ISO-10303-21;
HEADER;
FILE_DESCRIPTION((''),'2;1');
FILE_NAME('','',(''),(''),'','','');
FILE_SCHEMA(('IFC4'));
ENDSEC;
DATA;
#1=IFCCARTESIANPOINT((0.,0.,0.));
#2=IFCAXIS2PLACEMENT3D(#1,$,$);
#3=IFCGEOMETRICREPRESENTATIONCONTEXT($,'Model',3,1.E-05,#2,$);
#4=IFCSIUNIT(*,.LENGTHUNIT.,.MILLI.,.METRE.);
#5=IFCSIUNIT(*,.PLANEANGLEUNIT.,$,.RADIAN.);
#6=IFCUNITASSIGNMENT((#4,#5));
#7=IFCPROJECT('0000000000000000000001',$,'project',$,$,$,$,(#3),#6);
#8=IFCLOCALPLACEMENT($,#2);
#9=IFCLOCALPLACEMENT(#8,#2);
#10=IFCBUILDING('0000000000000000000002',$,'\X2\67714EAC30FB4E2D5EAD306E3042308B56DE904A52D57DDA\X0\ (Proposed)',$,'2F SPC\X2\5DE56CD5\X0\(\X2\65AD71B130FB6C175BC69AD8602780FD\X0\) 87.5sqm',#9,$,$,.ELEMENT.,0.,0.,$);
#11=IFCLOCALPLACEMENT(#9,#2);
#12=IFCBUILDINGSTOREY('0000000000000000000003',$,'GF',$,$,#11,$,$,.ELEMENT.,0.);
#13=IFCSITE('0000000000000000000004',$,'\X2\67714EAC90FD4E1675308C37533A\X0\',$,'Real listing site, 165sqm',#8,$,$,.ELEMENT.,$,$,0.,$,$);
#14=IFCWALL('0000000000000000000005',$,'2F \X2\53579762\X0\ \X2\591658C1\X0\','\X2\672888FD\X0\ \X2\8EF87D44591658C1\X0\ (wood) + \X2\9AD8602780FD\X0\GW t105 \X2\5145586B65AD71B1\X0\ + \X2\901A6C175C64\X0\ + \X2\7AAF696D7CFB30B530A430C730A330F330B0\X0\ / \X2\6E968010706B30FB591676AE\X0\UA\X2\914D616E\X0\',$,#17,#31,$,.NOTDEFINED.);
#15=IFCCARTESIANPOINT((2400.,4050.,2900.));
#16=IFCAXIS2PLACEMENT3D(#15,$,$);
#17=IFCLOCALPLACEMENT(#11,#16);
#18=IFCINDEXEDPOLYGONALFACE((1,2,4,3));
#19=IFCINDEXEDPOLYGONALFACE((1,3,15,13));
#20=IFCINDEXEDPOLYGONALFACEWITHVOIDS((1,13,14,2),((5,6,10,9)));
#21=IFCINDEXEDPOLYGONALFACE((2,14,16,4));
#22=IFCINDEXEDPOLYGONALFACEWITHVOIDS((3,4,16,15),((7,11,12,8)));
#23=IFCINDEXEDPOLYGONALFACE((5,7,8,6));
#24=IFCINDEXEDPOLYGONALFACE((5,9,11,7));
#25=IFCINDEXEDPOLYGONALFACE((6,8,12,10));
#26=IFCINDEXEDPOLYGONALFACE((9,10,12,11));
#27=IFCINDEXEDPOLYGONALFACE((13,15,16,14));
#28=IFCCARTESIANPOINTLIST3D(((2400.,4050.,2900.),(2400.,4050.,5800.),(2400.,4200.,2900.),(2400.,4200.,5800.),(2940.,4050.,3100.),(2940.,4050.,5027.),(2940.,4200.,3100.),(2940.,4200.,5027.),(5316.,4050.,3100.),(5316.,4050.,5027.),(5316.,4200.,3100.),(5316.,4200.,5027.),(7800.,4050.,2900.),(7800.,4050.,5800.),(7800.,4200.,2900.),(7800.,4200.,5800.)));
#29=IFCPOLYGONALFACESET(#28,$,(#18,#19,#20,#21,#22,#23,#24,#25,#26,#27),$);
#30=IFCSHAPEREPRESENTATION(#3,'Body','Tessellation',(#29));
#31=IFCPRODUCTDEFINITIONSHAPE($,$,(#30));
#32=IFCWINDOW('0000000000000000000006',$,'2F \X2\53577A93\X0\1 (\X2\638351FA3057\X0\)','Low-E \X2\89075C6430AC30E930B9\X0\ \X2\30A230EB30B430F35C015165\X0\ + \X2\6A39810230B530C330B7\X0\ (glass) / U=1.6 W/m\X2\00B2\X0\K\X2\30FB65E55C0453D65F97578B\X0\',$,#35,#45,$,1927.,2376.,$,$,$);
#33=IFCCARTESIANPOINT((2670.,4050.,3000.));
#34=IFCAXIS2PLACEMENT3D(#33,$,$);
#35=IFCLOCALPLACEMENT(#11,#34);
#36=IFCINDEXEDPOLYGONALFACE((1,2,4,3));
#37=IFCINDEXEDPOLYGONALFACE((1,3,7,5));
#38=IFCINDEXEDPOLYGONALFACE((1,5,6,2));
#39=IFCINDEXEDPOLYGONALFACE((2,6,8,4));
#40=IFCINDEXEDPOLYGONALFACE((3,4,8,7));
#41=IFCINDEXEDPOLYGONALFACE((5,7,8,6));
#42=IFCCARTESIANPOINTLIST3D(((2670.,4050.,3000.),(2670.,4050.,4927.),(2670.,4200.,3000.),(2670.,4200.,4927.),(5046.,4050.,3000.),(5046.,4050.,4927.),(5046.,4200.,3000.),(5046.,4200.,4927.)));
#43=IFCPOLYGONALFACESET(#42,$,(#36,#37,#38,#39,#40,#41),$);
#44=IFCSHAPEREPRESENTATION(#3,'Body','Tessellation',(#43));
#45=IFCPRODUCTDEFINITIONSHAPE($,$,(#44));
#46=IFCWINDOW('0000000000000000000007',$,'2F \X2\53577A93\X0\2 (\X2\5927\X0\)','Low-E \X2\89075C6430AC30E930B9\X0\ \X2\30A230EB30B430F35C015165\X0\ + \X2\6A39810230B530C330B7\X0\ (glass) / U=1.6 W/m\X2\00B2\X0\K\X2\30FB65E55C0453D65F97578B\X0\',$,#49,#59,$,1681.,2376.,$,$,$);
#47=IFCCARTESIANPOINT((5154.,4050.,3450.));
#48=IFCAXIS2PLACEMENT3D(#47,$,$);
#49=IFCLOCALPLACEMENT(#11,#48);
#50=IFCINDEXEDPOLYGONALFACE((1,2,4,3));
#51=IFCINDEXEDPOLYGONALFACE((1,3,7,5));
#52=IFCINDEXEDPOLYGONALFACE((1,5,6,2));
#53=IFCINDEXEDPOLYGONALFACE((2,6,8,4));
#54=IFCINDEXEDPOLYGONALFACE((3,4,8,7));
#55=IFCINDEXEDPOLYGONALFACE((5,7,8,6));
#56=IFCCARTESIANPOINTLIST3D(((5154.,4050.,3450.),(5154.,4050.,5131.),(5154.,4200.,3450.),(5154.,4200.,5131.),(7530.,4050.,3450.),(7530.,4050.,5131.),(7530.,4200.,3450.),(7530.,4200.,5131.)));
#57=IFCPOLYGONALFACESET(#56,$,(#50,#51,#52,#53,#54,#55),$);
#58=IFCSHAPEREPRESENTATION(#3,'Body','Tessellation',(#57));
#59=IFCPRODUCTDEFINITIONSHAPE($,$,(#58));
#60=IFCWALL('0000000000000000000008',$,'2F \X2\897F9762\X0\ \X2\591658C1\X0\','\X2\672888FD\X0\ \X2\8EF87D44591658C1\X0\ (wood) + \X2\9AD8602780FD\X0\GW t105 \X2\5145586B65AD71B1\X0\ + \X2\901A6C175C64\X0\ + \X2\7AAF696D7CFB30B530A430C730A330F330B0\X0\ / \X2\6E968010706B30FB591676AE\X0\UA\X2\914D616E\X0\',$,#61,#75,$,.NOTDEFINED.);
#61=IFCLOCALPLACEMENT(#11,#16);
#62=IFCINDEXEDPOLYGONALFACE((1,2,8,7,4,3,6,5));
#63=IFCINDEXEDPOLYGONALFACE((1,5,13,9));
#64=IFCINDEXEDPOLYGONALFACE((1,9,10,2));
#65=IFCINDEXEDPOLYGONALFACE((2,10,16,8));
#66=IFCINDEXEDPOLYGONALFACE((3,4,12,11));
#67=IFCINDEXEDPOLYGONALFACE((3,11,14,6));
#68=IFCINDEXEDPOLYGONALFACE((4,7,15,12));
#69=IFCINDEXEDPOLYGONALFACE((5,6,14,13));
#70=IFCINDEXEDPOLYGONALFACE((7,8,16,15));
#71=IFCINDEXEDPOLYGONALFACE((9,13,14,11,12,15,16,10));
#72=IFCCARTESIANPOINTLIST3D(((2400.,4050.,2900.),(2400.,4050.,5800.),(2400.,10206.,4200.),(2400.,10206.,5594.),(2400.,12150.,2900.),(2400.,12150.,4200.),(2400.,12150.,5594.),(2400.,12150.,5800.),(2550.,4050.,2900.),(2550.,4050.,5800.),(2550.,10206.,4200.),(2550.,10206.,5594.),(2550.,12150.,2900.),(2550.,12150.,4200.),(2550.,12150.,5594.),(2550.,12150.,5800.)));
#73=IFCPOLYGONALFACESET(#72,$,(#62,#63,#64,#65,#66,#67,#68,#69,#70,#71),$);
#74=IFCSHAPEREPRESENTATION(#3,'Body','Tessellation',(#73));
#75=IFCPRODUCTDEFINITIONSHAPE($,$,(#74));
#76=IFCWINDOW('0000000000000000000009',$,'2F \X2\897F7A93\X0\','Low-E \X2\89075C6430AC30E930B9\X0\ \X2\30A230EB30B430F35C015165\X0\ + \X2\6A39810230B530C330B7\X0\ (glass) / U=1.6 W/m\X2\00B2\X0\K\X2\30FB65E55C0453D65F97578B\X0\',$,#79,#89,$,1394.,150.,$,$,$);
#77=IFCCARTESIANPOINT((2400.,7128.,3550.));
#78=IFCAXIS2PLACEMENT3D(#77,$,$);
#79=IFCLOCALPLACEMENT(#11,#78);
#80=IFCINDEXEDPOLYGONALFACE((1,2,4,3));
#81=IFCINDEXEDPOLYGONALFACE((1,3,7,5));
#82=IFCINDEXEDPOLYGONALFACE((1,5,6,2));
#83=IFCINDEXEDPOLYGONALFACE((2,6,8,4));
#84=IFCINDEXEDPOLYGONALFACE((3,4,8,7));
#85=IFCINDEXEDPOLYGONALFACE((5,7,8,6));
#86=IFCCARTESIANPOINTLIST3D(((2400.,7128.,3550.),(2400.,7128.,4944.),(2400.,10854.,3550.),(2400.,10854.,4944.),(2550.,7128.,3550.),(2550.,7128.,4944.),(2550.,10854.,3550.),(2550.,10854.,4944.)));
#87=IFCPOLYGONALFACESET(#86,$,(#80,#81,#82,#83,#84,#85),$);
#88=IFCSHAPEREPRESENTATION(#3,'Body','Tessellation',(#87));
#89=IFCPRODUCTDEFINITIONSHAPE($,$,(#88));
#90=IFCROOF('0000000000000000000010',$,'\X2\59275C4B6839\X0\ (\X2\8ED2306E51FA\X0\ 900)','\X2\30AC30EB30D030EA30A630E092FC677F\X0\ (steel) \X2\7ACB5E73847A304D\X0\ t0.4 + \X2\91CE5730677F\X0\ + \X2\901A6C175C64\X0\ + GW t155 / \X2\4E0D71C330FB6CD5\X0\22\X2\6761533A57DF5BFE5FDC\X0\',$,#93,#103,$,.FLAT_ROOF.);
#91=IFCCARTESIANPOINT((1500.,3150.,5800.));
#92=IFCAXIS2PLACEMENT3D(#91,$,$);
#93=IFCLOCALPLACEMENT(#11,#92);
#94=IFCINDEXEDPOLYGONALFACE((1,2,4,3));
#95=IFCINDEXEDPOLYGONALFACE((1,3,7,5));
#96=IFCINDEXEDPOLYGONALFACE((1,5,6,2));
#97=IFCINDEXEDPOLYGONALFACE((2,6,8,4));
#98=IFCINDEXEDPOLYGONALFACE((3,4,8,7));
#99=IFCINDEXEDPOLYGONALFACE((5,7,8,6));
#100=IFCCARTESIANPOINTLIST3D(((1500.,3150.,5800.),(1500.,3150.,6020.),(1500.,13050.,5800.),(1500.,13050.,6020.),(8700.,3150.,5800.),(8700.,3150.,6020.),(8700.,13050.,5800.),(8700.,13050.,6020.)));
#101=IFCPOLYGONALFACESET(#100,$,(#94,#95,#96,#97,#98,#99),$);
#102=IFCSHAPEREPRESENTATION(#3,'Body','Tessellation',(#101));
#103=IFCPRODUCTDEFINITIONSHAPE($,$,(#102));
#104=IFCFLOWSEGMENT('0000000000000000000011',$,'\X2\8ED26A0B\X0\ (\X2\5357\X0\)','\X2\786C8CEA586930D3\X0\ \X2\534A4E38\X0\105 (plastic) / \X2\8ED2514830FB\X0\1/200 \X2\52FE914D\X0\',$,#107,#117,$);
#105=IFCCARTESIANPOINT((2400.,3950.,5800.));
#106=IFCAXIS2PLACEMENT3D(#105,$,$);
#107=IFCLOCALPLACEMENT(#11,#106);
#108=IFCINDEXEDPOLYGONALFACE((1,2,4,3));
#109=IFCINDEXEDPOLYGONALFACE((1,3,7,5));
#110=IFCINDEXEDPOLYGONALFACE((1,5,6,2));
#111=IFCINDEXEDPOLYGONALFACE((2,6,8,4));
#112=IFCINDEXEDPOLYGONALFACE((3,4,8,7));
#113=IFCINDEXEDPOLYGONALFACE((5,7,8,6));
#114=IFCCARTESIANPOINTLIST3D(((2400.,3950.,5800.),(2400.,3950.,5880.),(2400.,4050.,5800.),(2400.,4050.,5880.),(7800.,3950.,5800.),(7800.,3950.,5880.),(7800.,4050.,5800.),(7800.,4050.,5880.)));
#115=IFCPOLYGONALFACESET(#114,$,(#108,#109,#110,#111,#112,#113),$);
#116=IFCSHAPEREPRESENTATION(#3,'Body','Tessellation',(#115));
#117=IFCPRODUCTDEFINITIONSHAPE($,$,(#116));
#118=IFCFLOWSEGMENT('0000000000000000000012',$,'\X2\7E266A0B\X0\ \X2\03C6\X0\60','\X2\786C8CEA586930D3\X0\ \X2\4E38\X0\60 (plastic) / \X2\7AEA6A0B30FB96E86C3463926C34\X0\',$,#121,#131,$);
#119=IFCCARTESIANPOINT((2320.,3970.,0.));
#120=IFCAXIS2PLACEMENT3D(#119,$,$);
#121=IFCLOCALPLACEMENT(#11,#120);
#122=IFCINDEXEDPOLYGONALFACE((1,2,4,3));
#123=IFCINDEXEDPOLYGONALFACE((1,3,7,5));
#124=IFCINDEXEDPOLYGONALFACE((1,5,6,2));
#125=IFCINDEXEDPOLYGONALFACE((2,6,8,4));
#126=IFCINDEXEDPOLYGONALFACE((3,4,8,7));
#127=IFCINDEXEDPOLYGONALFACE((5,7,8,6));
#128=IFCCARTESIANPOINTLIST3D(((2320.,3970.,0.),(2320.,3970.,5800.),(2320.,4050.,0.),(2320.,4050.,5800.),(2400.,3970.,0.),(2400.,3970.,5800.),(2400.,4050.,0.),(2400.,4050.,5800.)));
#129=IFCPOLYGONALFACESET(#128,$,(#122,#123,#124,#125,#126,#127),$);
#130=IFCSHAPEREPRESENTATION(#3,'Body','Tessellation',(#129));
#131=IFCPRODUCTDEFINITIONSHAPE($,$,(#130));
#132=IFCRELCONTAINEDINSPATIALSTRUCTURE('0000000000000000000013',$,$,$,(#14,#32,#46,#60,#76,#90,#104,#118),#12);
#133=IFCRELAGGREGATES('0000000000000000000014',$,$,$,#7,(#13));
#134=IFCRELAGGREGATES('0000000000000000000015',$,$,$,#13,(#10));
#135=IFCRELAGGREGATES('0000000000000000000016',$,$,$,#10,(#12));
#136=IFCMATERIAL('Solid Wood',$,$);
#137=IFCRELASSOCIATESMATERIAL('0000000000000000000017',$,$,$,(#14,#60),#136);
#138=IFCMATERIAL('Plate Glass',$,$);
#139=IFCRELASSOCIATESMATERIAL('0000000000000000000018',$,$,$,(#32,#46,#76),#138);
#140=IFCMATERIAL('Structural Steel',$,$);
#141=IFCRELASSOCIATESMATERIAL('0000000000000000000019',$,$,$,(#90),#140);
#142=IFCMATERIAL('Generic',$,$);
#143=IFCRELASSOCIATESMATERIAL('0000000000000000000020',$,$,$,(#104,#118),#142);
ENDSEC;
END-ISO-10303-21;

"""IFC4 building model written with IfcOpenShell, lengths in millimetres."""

from ifc_helpers import new_model, si_unit, frame, frame_2d, origin, place, context, project, spatial, rectangle, extrude, material, element, fill, save


model = new_model("IFC4")

# Units and contexts
model_context = context("Model", 3, precision=1e-05, world=origin())
ifc_project = project(units=[si_unit("LENGTHUNIT", "METRE", prefix="MILLI"), si_unit("PLANEANGLEUNIT", "RADIAN")], contexts=[model_context])

# Site, building, storey
site_placement = place(None, origin())
site = spatial("IfcSite", under=ifc_project, at=site_placement, Name="東京都世田谷区", ObjectType="Real listing site, 165sqm", CompositionType="ELEMENT", RefElevation=0.0)
building_placement = place(site_placement, origin())
building = spatial("IfcBuilding", under=site, at=building_placement, Name="東京・中庭のある回遊動線 (Proposed)", ObjectType="2F SPC工法(断熱・気密高性能) 87.5sqm", CompositionType="ELEMENT", ElevationOfRefHeight=0.0, ElevationOfTerrain=0.0)
storey_placement = place(building_placement, origin())
storey = spatial("IfcBuildingStorey", under=building, at=storey_placement, Name="GF", CompositionType="ELEMENT", Elevation=0.0)

# Shared definitions
ifc_material_1 = material(Name="Solid Wood")

# Shared definitions
ifc_material_2 = material(Name="Plate Glass")

# Wall, openings, windows
wall_1_placement = place(storey_placement, frame((2400.0, 4050.0, 2900.0)))
wall_1 = element("IfcWall", 1, at=wall_1_placement, inside=storey, material=ifc_material_1, Name="2F 南面 外壁", Description="木製 軸組外壁 (wood) + 高性能GW t105 充填断熱 + 通気層 + 窯業系サイディング / 準耐火・外皮UA配慮", PredefinedType="NOTDEFINED", context=model_context, shape_type="SweptSolid", body=[
    extrude(rectangle(XDim=5400.0, YDim=150.0, at=frame_2d((2700.0, 75.0))), frame((2400.0, 4050.0, 2900.0)), (0.0, 0.0, 1.0), 2900.0),
])
opening_1_placement = place(storey_placement, frame((2670.0, 4050.0, 3000.0)))
opening_1 = element("IfcOpeningElement", 2, at=opening_1_placement, cuts=wall_1, PredefinedType="NOTDEFINED", context=model_context, shape_type="SweptSolid", body=[
    extrude(rectangle(XDim=2376.0, YDim=150.0, at=frame_2d((1188.0, 75.0))), frame((2670.0, 4050.0, 3000.0)), (0.0, 0.0, 1.0), 1927.0),
])
opening_2_placement = place(storey_placement, frame((5154.0, 4050.0, 3450.0)))
opening_2 = element("IfcOpeningElement", 3, at=opening_2_placement, cuts=wall_1, PredefinedType="NOTDEFINED", context=model_context, shape_type="SweptSolid", body=[
    extrude(rectangle(XDim=2376.0, YDim=150.0, at=frame_2d((1188.0, 75.0))), frame((5154.0, 4050.0, 3450.0)), (0.0, 0.0, 1.0), 1681.0),
])
window_1_placement = place(storey_placement, frame((2670.0, 4050.0, 3000.0)))
window_1 = element("IfcWindow", 4, at=window_1_placement, inside=storey, material=ifc_material_2, Name="2F 南窓1 (掃出し)", Description="Low-E 複層ガラス アルゴン封入 + 樹脂サッシ (glass) / U=1.6 W/m²K・日射取得型", OverallHeight=1927.0, OverallWidth=2376.0, context=model_context, shape_type="SweptSolid", body=[
    extrude(rectangle(XDim=2376.0, YDim=150.0, at=frame_2d((1188.0, 75.0))), frame((2670.0, 4050.0, 3000.0)), (0.0, 0.0, 1.0), 1927.0),
])
fill(opening_1, window_1)
window_2_placement = place(storey_placement, frame((5154.0, 4050.0, 3450.0)))
window_2 = element("IfcWindow", 5, at=window_2_placement, inside=storey, material=ifc_material_2, Name="2F 南窓2 (大)", Description="Low-E 複層ガラス アルゴン封入 + 樹脂サッシ (glass) / U=1.6 W/m²K・日射取得型", OverallHeight=1681.0, OverallWidth=2376.0, context=model_context, shape_type="SweptSolid", body=[
    extrude(rectangle(XDim=2376.0, YDim=150.0, at=frame_2d((1188.0, 75.0))), frame((5154.0, 4050.0, 3450.0)), (0.0, 0.0, 1.0), 1681.0),
])
fill(opening_2, window_2)

# Wall, opening, window
wall_2_placement = place(storey_placement, frame((2400.0, 4050.0, 2900.0)))
wall_2 = element("IfcWall", 6, at=wall_2_placement, inside=storey, material=ifc_material_1, Name="2F 西面 外壁", Description="木製 軸組外壁 (wood) + 高性能GW t105 充填断熱 + 通気層 + 窯業系サイディング / 準耐火・外皮UA配慮", PredefinedType="NOTDEFINED", context=model_context, shape_type="SweptSolid", body=[
    extrude(rectangle(XDim=150.0, YDim=8100.0, at=frame_2d((75.0, 4050.0))), frame((2400.0, 4050.0, 2900.0)), (0.0, 0.0, 1.0), 2900.0),
])
opening_3_placement = place(storey_placement, frame((2400.0, 7128.0, 3550.0)))
opening_3 = element("IfcOpeningElement", 7, at=opening_3_placement, cuts=wall_2, PredefinedType="NOTDEFINED", context=model_context, shape_type="SweptSolid", body=[
    extrude(rectangle(XDim=150.0, YDim=3726.0, at=frame_2d((75.0, 1863.0))), frame((2400.0, 7128.0, 3550.0)), (0.0, 0.0, 1.0), 1394.0),
])
window_3_placement = place(storey_placement, frame((2400.0, 7128.0, 3550.0)))
window_3 = element("IfcWindow", 8, at=window_3_placement, inside=storey, material=ifc_material_2, Name="2F 西窓", Description="Low-E 複層ガラス アルゴン封入 + 樹脂サッシ (glass) / U=1.6 W/m²K・日射取得型", OverallHeight=1394.0, OverallWidth=150.0, context=model_context, shape_type="SweptSolid", body=[
    extrude(rectangle(XDim=150.0, YDim=3726.0, at=frame_2d((75.0, 1863.0))), frame((2400.0, 7128.0, 3550.0)), (0.0, 0.0, 1.0), 1394.0),
])
fill(opening_3, window_3)

# Roof
ifc_material_3 = material(Name="Structural Steel")
roof_placement = place(storey_placement, frame((1500.0, 3150.0, 5800.0)))
element("IfcRoof", 9, at=roof_placement, inside=storey, material=ifc_material_3, Name="大屋根 (軒の出 900)", Description="ガルバリウム鋼板 (steel) 立平葺き t0.4 + 野地板 + 通気層 + GW t155 / 不燃・法22条区域対応", PredefinedType="FLAT_ROOF", context=model_context, shape_type="SweptSolid", body=[
    extrude(rectangle(XDim=7200.0, YDim=9900.0, at=frame_2d((3600.0, 4950.0))), frame((1500.0, 3150.0, 5800.0)), (0.0, 0.0, 1.0), 220.0),
])

# Flow segments
ifc_material_4 = material(Name="Generic")
flow_segment_1_placement = place(storey_placement, frame((2400.0, 3950.0, 5800.0)))
element("IfcFlowSegment", 10, at=flow_segment_1_placement, inside=storey, material=ifc_material_4, Name="軒樋 (南)", Description="硬質塩ビ 半丸105 (plastic) / 軒先・1/200 勾配", context=model_context, shape_type="SweptSolid", body=[
    extrude(rectangle(XDim=5400.0, YDim=100.0, at=frame_2d((2700.0, 50.0))), frame((2400.0, 3950.0, 5800.0)), (0.0, 0.0, 1.0), 80.0),
])
flow_segment_2_placement = place(storey_placement, frame((2320.0, 3970.0, 0.0)))
element("IfcFlowSegment", 11, at=flow_segment_2_placement, inside=storey, material=ifc_material_4, Name="縦樋 φ60", Description="硬質塩ビ 丸60 (plastic) / 竪樋・雨水排水", context=model_context, shape_type="SweptSolid", body=[
    extrude(rectangle(XDim=80.0, YDim=80.0, at=frame_2d((40.0, 40.0))), frame((2320.0, 3970.0, 0.0)), (0.0, 0.0, 1.0), 5800.0),
])

save(model, "model.ifc")
